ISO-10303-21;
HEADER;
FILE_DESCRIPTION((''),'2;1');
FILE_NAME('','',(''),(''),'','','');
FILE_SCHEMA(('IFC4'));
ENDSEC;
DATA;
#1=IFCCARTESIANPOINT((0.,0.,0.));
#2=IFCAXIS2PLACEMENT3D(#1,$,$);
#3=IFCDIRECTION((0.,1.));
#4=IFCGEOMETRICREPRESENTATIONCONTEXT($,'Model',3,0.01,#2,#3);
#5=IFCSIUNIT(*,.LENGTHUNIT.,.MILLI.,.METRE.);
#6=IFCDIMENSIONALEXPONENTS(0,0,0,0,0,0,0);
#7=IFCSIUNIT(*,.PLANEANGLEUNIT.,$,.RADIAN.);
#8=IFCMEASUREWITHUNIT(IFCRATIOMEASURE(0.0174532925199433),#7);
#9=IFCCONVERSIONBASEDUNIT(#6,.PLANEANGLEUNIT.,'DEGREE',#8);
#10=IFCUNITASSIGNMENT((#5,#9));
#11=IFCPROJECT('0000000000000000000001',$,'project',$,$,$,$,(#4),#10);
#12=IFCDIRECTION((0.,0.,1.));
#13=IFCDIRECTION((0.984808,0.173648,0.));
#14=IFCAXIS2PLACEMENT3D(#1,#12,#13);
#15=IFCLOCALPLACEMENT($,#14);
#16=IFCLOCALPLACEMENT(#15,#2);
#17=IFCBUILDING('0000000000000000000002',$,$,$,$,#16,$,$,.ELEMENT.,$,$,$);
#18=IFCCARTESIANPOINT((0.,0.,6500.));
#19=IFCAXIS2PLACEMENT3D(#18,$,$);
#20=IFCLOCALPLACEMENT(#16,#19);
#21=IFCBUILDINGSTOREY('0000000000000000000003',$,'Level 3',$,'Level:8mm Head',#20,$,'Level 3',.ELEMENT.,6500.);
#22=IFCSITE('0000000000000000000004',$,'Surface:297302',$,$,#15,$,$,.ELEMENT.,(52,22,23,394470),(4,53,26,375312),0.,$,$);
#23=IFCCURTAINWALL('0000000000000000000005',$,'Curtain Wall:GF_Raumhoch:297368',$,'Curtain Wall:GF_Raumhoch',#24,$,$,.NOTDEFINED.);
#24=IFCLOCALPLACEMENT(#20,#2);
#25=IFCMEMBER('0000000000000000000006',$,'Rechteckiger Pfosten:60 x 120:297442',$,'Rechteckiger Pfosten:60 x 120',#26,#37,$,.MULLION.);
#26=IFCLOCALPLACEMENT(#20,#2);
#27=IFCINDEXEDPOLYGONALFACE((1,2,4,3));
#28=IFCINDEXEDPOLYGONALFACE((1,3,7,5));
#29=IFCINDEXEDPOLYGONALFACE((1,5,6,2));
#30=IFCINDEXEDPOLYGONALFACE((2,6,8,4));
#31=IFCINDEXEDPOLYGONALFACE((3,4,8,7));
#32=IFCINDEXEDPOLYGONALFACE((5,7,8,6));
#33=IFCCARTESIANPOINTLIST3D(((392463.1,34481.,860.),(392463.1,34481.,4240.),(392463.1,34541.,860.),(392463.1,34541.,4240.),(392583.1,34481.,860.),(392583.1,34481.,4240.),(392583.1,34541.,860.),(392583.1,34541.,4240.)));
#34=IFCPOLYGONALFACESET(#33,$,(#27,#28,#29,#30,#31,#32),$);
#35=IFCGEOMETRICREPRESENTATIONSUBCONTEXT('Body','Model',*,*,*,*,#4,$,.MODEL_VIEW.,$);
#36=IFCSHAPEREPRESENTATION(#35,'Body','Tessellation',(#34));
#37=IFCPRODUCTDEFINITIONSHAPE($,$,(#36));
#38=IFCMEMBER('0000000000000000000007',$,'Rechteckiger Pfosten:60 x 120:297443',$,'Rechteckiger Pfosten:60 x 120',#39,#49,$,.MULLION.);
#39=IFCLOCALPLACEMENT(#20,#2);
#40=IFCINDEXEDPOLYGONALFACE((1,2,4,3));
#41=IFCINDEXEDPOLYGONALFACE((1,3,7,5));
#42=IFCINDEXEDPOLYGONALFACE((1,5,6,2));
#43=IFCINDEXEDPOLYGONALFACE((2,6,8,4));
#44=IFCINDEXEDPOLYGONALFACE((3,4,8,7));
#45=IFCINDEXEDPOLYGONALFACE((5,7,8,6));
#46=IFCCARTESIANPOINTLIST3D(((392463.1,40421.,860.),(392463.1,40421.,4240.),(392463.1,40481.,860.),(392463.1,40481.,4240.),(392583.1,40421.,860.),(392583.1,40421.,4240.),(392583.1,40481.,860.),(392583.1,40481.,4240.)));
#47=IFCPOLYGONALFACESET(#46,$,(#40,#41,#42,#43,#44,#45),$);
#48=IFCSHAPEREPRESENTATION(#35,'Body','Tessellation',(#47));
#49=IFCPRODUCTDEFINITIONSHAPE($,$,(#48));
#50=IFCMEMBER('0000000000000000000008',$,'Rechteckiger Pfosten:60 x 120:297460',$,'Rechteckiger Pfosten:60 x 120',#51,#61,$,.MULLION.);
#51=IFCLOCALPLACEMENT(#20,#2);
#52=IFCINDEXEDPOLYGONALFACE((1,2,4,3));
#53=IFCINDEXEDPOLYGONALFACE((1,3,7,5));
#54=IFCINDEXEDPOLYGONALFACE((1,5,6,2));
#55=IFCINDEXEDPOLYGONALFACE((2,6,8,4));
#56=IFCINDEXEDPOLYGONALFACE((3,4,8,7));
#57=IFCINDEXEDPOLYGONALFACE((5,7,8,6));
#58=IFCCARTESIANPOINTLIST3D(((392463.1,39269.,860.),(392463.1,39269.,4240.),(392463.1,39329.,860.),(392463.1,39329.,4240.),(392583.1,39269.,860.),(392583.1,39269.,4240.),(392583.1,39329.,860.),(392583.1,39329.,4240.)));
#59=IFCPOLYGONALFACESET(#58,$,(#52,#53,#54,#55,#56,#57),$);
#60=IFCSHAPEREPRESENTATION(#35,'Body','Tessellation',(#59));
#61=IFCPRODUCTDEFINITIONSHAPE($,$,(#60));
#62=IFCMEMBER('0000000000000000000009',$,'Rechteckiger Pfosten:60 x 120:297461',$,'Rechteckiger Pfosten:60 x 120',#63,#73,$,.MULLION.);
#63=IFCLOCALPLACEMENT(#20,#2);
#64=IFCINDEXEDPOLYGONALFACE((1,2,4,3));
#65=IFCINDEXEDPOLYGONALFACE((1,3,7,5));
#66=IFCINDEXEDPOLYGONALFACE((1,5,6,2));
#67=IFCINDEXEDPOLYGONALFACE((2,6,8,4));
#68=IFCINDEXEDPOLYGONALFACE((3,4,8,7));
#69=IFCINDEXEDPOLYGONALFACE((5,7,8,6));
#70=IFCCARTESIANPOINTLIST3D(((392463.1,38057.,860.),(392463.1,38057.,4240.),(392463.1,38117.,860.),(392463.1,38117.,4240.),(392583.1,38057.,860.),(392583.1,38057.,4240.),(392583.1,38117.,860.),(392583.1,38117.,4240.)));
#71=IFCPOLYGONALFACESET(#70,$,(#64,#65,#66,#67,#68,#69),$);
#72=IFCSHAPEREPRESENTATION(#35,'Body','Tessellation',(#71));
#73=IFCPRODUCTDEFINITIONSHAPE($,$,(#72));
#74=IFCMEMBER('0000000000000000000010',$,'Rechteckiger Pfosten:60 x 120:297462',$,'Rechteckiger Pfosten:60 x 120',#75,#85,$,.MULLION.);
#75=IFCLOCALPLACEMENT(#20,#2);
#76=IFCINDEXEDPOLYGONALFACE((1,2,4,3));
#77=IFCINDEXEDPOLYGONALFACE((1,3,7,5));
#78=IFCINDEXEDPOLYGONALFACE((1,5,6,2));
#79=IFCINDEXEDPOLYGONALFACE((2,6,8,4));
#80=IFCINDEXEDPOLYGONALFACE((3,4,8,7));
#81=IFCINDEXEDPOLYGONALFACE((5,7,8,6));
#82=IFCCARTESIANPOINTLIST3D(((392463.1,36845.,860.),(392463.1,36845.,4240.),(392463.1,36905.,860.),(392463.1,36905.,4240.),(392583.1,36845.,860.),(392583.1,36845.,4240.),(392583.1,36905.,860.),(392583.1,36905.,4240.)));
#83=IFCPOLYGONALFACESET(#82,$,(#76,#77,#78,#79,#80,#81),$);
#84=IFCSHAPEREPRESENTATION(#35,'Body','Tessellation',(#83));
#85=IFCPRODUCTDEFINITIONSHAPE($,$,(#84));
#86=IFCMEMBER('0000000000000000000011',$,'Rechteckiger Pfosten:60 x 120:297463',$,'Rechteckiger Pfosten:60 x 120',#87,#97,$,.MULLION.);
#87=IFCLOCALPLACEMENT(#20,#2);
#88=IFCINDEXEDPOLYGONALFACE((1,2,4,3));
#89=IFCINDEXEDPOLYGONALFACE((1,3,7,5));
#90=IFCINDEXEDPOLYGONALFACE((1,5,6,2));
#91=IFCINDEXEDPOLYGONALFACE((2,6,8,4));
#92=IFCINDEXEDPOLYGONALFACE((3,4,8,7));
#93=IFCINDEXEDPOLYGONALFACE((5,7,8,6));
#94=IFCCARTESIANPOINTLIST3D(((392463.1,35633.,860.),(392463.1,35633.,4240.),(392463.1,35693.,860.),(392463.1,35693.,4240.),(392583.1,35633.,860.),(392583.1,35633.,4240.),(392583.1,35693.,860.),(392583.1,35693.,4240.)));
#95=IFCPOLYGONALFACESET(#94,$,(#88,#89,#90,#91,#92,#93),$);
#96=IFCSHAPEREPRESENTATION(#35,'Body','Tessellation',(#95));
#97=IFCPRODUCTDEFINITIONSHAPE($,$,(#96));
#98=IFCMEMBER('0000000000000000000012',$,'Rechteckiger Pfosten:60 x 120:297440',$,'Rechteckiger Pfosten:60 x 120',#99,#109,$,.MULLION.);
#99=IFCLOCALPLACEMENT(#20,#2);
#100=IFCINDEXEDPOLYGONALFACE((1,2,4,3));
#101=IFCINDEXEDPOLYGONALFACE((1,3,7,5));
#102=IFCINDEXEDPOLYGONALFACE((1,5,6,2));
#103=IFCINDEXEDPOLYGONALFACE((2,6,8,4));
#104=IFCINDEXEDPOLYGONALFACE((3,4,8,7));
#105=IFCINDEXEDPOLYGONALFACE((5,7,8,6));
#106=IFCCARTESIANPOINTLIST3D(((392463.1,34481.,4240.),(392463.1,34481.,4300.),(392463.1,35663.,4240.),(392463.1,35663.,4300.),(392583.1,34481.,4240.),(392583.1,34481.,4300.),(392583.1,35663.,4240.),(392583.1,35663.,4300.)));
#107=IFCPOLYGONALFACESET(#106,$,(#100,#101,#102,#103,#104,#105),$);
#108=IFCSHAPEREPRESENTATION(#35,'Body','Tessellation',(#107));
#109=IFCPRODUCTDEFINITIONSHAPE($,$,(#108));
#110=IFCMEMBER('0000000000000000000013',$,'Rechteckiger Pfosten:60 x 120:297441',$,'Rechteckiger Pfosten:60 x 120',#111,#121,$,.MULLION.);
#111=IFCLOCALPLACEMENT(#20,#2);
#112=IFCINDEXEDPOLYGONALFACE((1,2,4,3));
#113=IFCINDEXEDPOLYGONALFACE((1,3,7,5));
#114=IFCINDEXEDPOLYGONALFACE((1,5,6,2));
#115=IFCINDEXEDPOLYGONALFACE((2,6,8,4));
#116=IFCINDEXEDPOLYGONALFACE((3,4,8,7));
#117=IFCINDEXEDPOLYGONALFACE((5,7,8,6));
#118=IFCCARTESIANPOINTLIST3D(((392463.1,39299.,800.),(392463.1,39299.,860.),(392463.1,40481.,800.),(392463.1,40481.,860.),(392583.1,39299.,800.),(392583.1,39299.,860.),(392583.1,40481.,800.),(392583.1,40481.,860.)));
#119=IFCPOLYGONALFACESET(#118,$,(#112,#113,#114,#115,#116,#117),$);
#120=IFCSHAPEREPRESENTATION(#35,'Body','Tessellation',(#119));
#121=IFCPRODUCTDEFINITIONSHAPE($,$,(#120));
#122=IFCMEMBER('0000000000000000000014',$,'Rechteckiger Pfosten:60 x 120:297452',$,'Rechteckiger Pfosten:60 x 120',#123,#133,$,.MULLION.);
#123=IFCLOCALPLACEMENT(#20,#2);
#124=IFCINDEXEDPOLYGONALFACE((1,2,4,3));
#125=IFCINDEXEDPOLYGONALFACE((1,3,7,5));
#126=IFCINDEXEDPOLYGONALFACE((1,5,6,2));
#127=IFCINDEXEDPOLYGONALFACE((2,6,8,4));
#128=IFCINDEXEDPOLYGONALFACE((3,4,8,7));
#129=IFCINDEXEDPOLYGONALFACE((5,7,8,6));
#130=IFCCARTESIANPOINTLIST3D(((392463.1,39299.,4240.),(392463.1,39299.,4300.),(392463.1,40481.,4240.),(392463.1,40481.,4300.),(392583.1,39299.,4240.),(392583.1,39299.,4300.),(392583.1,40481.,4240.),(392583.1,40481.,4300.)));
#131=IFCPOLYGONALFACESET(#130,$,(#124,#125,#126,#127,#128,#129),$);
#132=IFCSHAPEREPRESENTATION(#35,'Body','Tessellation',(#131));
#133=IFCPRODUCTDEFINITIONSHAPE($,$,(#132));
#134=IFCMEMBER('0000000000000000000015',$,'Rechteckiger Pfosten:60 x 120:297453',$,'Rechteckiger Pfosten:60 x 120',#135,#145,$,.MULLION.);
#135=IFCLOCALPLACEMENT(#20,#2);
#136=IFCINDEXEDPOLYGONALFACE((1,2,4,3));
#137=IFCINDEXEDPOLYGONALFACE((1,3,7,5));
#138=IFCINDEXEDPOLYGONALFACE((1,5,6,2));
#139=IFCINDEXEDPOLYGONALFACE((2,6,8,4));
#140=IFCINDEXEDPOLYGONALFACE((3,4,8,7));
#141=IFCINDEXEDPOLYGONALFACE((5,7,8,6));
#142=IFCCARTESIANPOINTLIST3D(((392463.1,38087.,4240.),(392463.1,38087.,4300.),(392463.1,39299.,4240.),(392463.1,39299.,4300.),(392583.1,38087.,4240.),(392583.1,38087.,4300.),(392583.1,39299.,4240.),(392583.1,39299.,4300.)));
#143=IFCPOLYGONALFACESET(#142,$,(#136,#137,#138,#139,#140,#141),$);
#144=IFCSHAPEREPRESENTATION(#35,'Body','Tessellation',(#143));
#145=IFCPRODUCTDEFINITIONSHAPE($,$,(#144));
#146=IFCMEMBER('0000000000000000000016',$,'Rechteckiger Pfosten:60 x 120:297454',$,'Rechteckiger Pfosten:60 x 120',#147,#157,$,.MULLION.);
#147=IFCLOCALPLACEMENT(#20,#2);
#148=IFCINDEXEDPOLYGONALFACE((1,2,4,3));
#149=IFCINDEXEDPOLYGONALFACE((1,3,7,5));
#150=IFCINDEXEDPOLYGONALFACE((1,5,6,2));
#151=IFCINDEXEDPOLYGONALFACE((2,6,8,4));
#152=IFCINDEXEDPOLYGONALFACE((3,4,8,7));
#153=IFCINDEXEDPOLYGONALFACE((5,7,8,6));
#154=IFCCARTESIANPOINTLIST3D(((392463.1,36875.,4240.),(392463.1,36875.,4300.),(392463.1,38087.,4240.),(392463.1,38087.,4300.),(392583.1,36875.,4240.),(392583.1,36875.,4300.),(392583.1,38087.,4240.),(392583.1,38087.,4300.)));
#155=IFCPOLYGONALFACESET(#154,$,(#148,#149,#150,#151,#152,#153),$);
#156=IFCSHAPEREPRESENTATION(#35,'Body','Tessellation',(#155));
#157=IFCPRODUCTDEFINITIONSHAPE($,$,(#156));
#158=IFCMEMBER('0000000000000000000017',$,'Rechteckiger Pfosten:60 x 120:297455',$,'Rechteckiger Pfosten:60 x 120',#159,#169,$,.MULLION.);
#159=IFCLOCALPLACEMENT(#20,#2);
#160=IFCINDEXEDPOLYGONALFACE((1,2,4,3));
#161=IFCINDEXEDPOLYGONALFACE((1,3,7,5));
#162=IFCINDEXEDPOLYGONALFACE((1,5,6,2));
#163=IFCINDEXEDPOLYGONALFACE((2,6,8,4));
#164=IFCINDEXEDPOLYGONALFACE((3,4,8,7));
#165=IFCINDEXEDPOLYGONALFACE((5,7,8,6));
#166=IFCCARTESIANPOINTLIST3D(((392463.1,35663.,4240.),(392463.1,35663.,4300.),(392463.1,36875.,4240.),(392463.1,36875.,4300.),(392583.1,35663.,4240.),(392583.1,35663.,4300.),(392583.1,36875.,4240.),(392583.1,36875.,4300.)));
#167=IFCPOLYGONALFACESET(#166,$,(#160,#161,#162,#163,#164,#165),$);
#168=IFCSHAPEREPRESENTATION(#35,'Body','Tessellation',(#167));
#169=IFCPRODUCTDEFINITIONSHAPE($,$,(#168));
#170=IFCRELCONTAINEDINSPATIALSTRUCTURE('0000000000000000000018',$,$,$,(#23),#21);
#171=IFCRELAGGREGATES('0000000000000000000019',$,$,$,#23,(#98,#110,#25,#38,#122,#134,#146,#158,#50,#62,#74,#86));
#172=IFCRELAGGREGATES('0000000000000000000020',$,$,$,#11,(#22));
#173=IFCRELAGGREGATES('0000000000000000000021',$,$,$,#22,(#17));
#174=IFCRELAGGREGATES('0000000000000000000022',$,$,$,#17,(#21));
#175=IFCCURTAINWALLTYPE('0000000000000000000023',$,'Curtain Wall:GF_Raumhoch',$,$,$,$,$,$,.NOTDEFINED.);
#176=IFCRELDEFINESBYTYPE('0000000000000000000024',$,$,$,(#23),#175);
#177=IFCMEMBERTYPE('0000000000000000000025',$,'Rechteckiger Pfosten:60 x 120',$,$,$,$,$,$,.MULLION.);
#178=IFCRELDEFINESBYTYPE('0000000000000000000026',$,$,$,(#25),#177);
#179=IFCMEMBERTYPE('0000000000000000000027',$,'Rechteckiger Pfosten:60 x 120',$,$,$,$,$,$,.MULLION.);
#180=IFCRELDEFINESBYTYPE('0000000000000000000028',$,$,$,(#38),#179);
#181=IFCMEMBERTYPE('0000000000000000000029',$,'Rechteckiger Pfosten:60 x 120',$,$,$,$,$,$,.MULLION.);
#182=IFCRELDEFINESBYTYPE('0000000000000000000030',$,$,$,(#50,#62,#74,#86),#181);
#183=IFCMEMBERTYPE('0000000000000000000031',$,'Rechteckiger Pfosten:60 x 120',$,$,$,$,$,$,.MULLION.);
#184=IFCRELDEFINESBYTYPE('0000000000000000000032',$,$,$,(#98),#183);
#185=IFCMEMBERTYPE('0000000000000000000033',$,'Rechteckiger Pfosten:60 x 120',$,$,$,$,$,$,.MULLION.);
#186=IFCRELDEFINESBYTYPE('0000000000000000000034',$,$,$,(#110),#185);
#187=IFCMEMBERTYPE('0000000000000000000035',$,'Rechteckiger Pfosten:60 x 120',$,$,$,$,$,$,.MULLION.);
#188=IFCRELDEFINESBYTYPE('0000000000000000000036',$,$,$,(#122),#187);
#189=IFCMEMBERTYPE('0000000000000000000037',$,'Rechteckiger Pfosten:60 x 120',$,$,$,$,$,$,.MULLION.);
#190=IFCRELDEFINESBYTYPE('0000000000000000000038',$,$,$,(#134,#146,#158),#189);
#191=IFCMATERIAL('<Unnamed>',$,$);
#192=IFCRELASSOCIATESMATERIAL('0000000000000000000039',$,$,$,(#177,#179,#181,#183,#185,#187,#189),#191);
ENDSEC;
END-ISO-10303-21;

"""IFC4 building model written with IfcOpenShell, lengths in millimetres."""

from ifc_helpers import new_model, entity, si_unit, converted_unit, direction, frame, origin, place, context, subcontext, project, spatial, indexed_curve, outline, extrude, source, transform, mapped, material, type_object, type_shapes, element, aggregate, save


model = new_model("IFC4")

# Units and contexts
model_context = context("Model", 3, precision=0.01, world=origin(), true_north=direction((0.0, 1.0)))
body_context = subcontext(model_context, "Body", "Model", "MODEL_VIEW")
ifc_project = project(units=[si_unit("LENGTHUNIT", "METRE", prefix="MILLI"), converted_unit("PLANEANGLEUNIT", "DEGREE", entity("IfcRatioMeasure", 0.0174532925199433), si_unit("PLANEANGLEUNIT", "RADIAN"), dimensions=[0, 0, 0, 0, 0, 0, 0])], contexts=[model_context])

# Site, building, storey
site_placement = place(None, frame((0.0, 0.0, 0.0), z_axis=(0.0, 0.0, 1.0), x_axis=(0.984808, 0.173648, 0.0)))
site = spatial("IfcSite", under=ifc_project, at=site_placement, Name="Surface:297302", CompositionType="ELEMENT", RefLatitude=(52, 22, 23, 394470), RefLongitude=(4, 53, 26, 375312), RefElevation=0.0)
building_placement = place(site_placement, origin())
building = spatial("IfcBuilding", under=site, at=building_placement, CompositionType="ELEMENT")
storey_placement = place(building_placement, frame((0.0, 0.0, 6500.0)))
storey = spatial("IfcBuildingStorey", under=building, at=storey_placement, Name="Level 3", ObjectType="Level:8mm Head", LongName="Level 3", CompositionType="ELEMENT", Elevation=6500.0)

# Curtain wall, members
curtain_wall_type = type_object("IfcCurtainWallType", Name="Curtain Wall:GF_Raumhoch", PredefinedType="NOTDEFINED")
curtain_wall_placement = place(storey_placement, frame((0.0, 0.0, -6500.0)))
curtain_wall = element("IfcCurtainWall", 1, at=curtain_wall_placement, inside=storey, type_object=curtain_wall_type, Name="Curtain Wall:GF_Raumhoch:297368", ObjectType="Curtain Wall:GF_Raumhoch", PredefinedType="NOTDEFINED")
ifc_material_1 = material(Name="<Unnamed>")
member_type_1 = type_object("IfcMemberType", Name="Rechteckiger Pfosten:60 x 120", PredefinedType="MULLION", material=ifc_material_1)
shared_shape_1 = source(origin(), body_context, "Body", "SweptSolid", [
    extrude(outline(indexed_curve([(-60.0, -30.0), (60.0, -30.0), (60.0, 30.0), (-60.0, 30.0), (-60.0, -30.0)], self_intersect=False)), frame((-30.0, 0.0, -3380.0), z_axis=(0.0, 0.0, 1.0), x_axis=(0.0, -1.0, 0.0)), (0.0, 0.0, 1.0), 3380.0),
])
type_shapes(member_type_1, [shared_shape_1])
member_1_placement = place(curtain_wall_placement, frame((392523.1, 34481.0, 7360.0), z_axis=(0.0, 0.0, -1.0), x_axis=(0.0, -1.0, 0.0)))
member_1 = element("IfcMember", 2, at=member_1_placement, type_object=member_type_1, Name="Rechteckiger Pfosten:60 x 120:297442", ObjectType="Rechteckiger Pfosten:60 x 120", PredefinedType="MULLION", context=body_context, shape_type="MappedRepresentation", body=[
    mapped(shared_shape_1, transform((0.0, 0.0, 0.0), scale=1.0)),
])
member_type_2 = type_object("IfcMemberType", Name="Rechteckiger Pfosten:60 x 120", PredefinedType="MULLION", material=ifc_material_1)
shared_shape_2 = source(origin(), body_context, "Body", "SweptSolid", [
    extrude(outline(indexed_curve([(-60.0, -30.0), (60.0, -30.0), (60.0, 30.0), (-60.0, 30.0), (-60.0, -30.0)], self_intersect=False)), frame((-30.0, 0.0, -3380.0), z_axis=(0.0, 0.0, 1.0), x_axis=(0.0, -1.0, 0.0)), (0.0, 0.0, 1.0), 3380.0),
])
type_shapes(member_type_2, [shared_shape_2])
member_2_placement = place(curtain_wall_placement, frame((392523.1, 40481.0, 10740.0), z_axis=(0.0, 0.0, 1.0), x_axis=(0.0, 1.0, 0.0)))
member_2 = element("IfcMember", 3, at=member_2_placement, type_object=member_type_2, Name="Rechteckiger Pfosten:60 x 120:297443", ObjectType="Rechteckiger Pfosten:60 x 120", PredefinedType="MULLION", context=body_context, shape_type="MappedRepresentation", body=[
    mapped(shared_shape_2, transform((0.0, 0.0, 0.0), scale=1.0)),
])
member_type_3 = type_object("IfcMemberType", Name="Rechteckiger Pfosten:60 x 120", PredefinedType="MULLION", material=ifc_material_1)
shared_shape_3 = source(origin(), body_context, "Body", "SweptSolid", [
    extrude(outline(indexed_curve([(-60.0, -30.0), (60.0, -30.0), (60.0, 30.0), (-60.0, 30.0), (-60.0, -30.0)], self_intersect=False)), frame((0.0, 0.0, -3380.0), z_axis=(0.0, 0.0, 1.0), x_axis=(0.0, -1.0, 0.0)), (0.0, 0.0, 1.0), 3380.0),
])
type_shapes(member_type_3, [shared_shape_3])
member_3_placement = place(curtain_wall_placement, frame((392523.1, 39299.0, 7360.0), z_axis=(0.0, 0.0, -1.0), x_axis=(0.0, -1.0, 0.0)))
member_3 = element("IfcMember", 4, at=member_3_placement, type_object=member_type_3, Name="Rechteckiger Pfosten:60 x 120:297460", ObjectType="Rechteckiger Pfosten:60 x 120", PredefinedType="MULLION", context=body_context, shape_type="MappedRepresentation", body=[
    mapped(shared_shape_3, transform((0.0, 0.0, 0.0), scale=1.0)),
])
member_4_placement = place(curtain_wall_placement, frame((392523.1, 38087.0, 7360.0), z_axis=(0.0, 0.0, -1.0), x_axis=(0.0, -1.0, 0.0)))
member_4 = element("IfcMember", 5, at=member_4_placement, type_object=member_type_3, Name="Rechteckiger Pfosten:60 x 120:297461", ObjectType="Rechteckiger Pfosten:60 x 120", PredefinedType="MULLION", context=body_context, shape_type="MappedRepresentation", body=[
    mapped(shared_shape_3, transform((0.0, 0.0, 0.0), scale=1.0)),
])
member_5_placement = place(curtain_wall_placement, frame((392523.1, 36875.0, 7360.0), z_axis=(0.0, 0.0, -1.0), x_axis=(0.0, -1.0, 0.0)))
member_5 = element("IfcMember", 6, at=member_5_placement, type_object=member_type_3, Name="Rechteckiger Pfosten:60 x 120:297462", ObjectType="Rechteckiger Pfosten:60 x 120", PredefinedType="MULLION", context=body_context, shape_type="MappedRepresentation", body=[
    mapped(shared_shape_3, transform((0.0, 0.0, 0.0), scale=1.0)),
])
member_6_placement = place(curtain_wall_placement, frame((392523.1, 35663.0, 7360.0), z_axis=(0.0, 0.0, -1.0), x_axis=(0.0, -1.0, 0.0)))
member_6 = element("IfcMember", 7, at=member_6_placement, type_object=member_type_3, Name="Rechteckiger Pfosten:60 x 120:297463", ObjectType="Rechteckiger Pfosten:60 x 120", PredefinedType="MULLION", context=body_context, shape_type="MappedRepresentation", body=[
    mapped(shared_shape_3, transform((0.0, 0.0, 0.0), scale=1.0)),
])
member_type_4 = type_object("IfcMemberType", Name="Rechteckiger Pfosten:60 x 120", PredefinedType="MULLION", material=ifc_material_1)
shared_shape_4 = source(origin(), body_context, "Body", "SweptSolid", [
    extrude(outline(indexed_curve([(-60.0, -30.0), (60.0, -30.0), (60.0, 30.0), (-60.0, 30.0), (-60.0, -30.0)], self_intersect=False)), frame((-30.0, 0.0, -1182.0), z_axis=(0.0, 0.0, 1.0), x_axis=(0.0, -1.0, 0.0)), (0.0, 0.0, 1.0), 1182.0),
])
type_shapes(member_type_4, [shared_shape_4])
member_7_placement = place(curtain_wall_placement, frame((392523.1, 34481.0, 10800.0), z_axis=(0.0, -1.0, 0.0), x_axis=(0.0, 0.0, 1.0)))
member_7 = element("IfcMember", 8, at=member_7_placement, type_object=member_type_4, Name="Rechteckiger Pfosten:60 x 120:297440", ObjectType="Rechteckiger Pfosten:60 x 120", PredefinedType="MULLION", context=body_context, shape_type="MappedRepresentation", body=[
    mapped(shared_shape_4, transform((0.0, 0.0, 0.0), scale=1.0)),
])
member_type_5 = type_object("IfcMemberType", Name="Rechteckiger Pfosten:60 x 120", PredefinedType="MULLION", material=ifc_material_1)
shared_shape_5 = source(origin(), body_context, "Body", "SweptSolid", [
    extrude(outline(indexed_curve([(-60.0, -30.0), (60.0, -30.0), (60.0, 30.0), (-60.0, 30.0), (-60.0, -30.0)], self_intersect=False)), frame((-30.0, 0.0, -1182.0), z_axis=(0.0, 0.0, 1.0), x_axis=(0.0, -1.0, 0.0)), (0.0, 0.0, 1.0), 1182.0),
])
type_shapes(member_type_5, [shared_shape_5])
member_8_placement = place(curtain_wall_placement, frame((392523.1, 40481.0, 7300.0), z_axis=(0.0, 1.0, 0.0), x_axis=(0.0, 0.0, -1.0)))
member_8 = element("IfcMember", 9, at=member_8_placement, type_object=member_type_5, Name="Rechteckiger Pfosten:60 x 120:297441", ObjectType="Rechteckiger Pfosten:60 x 120", PredefinedType="MULLION", context=body_context, shape_type="MappedRepresentation", body=[
    mapped(shared_shape_5, transform((0.0, 0.0, 0.0), scale=1.0)),
])
member_type_6 = type_object("IfcMemberType", Name="Rechteckiger Pfosten:60 x 120", PredefinedType="MULLION", material=ifc_material_1)
shared_shape_6 = source(origin(), body_context, "Body", "SweptSolid", [
    extrude(outline(indexed_curve([(-60.0, -30.0), (60.0, -30.0), (60.0, 30.0), (-60.0, 30.0), (-60.0, -30.0)], self_intersect=False)), frame((-30.0, 0.0, -1182.0), z_axis=(0.0, 0.0, 1.0), x_axis=(0.0, -1.0, 0.0)), (0.0, 0.0, 1.0), 1182.0),
])
type_shapes(member_type_6, [shared_shape_6])
member_9_placement = place(curtain_wall_placement, frame((392523.1, 39299.0, 10800.0), z_axis=(0.0, -1.0, 0.0), x_axis=(0.0, 0.0, 1.0)))
member_9 = element("IfcMember", 10, at=member_9_placement, type_object=member_type_6, Name="Rechteckiger Pfosten:60 x 120:297452", ObjectType="Rechteckiger Pfosten:60 x 120", PredefinedType="MULLION", context=body_context, shape_type="MappedRepresentation", body=[
    mapped(shared_shape_6, transform((0.0, 0.0, 0.0), scale=1.0)),
])
member_type_7 = type_object("IfcMemberType", Name="Rechteckiger Pfosten:60 x 120", PredefinedType="MULLION", material=ifc_material_1)
shared_shape_7 = source(origin(), body_context, "Body", "SweptSolid", [
    extrude(outline(indexed_curve([(-60.0, -30.0), (60.0, -30.0), (60.0, 30.0), (-60.0, 30.0), (-60.0, -30.0)], self_intersect=False)), frame((-30.0, 0.0, -1212.0), z_axis=(0.0, 0.0, 1.0), x_axis=(0.0, -1.0, 0.0)), (0.0, 0.0, 1.0), 1212.0),
])
type_shapes(member_type_7, [shared_shape_7])
member_10_placement = place(curtain_wall_placement, frame((392523.1, 38087.0, 10800.0), z_axis=(0.0, -1.0, 0.0), x_axis=(0.0, 0.0, 1.0)))
member_10 = element("IfcMember", 11, at=member_10_placement, type_object=member_type_7, Name="Rechteckiger Pfosten:60 x 120:297453", ObjectType="Rechteckiger Pfosten:60 x 120", PredefinedType="MULLION", context=body_context, shape_type="MappedRepresentation", body=[
    mapped(shared_shape_7, transform((0.0, 0.0, 0.0), scale=1.0)),
])
member_11_placement = place(curtain_wall_placement, frame((392523.1, 36875.0, 10800.0), z_axis=(0.0, -1.0, 0.0), x_axis=(0.0, 0.0, 1.0)))
member_11 = element("IfcMember", 12, at=member_11_placement, type_object=member_type_7, Name="Rechteckiger Pfosten:60 x 120:297454", ObjectType="Rechteckiger Pfosten:60 x 120", PredefinedType="MULLION", context=body_context, shape_type="MappedRepresentation", body=[
    mapped(shared_shape_7, transform((0.0, 0.0, 0.0), scale=1.0)),
])
member_12_placement = place(curtain_wall_placement, frame((392523.1, 35663.0, 10800.0), z_axis=(0.0, -1.0, 0.0), x_axis=(0.0, 0.0, 1.0)))
member_12 = element("IfcMember", 13, at=member_12_placement, type_object=member_type_7, Name="Rechteckiger Pfosten:60 x 120:297455", ObjectType="Rechteckiger Pfosten:60 x 120", PredefinedType="MULLION", context=body_context, shape_type="MappedRepresentation", body=[
    mapped(shared_shape_7, transform((0.0, 0.0, 0.0), scale=1.0)),
])

aggregate(curtain_wall, [member_7, member_8, member_1, member_2, member_9, member_10, member_11, member_12, member_3, member_4, member_5, member_6])

save(model, "model.ifc")
